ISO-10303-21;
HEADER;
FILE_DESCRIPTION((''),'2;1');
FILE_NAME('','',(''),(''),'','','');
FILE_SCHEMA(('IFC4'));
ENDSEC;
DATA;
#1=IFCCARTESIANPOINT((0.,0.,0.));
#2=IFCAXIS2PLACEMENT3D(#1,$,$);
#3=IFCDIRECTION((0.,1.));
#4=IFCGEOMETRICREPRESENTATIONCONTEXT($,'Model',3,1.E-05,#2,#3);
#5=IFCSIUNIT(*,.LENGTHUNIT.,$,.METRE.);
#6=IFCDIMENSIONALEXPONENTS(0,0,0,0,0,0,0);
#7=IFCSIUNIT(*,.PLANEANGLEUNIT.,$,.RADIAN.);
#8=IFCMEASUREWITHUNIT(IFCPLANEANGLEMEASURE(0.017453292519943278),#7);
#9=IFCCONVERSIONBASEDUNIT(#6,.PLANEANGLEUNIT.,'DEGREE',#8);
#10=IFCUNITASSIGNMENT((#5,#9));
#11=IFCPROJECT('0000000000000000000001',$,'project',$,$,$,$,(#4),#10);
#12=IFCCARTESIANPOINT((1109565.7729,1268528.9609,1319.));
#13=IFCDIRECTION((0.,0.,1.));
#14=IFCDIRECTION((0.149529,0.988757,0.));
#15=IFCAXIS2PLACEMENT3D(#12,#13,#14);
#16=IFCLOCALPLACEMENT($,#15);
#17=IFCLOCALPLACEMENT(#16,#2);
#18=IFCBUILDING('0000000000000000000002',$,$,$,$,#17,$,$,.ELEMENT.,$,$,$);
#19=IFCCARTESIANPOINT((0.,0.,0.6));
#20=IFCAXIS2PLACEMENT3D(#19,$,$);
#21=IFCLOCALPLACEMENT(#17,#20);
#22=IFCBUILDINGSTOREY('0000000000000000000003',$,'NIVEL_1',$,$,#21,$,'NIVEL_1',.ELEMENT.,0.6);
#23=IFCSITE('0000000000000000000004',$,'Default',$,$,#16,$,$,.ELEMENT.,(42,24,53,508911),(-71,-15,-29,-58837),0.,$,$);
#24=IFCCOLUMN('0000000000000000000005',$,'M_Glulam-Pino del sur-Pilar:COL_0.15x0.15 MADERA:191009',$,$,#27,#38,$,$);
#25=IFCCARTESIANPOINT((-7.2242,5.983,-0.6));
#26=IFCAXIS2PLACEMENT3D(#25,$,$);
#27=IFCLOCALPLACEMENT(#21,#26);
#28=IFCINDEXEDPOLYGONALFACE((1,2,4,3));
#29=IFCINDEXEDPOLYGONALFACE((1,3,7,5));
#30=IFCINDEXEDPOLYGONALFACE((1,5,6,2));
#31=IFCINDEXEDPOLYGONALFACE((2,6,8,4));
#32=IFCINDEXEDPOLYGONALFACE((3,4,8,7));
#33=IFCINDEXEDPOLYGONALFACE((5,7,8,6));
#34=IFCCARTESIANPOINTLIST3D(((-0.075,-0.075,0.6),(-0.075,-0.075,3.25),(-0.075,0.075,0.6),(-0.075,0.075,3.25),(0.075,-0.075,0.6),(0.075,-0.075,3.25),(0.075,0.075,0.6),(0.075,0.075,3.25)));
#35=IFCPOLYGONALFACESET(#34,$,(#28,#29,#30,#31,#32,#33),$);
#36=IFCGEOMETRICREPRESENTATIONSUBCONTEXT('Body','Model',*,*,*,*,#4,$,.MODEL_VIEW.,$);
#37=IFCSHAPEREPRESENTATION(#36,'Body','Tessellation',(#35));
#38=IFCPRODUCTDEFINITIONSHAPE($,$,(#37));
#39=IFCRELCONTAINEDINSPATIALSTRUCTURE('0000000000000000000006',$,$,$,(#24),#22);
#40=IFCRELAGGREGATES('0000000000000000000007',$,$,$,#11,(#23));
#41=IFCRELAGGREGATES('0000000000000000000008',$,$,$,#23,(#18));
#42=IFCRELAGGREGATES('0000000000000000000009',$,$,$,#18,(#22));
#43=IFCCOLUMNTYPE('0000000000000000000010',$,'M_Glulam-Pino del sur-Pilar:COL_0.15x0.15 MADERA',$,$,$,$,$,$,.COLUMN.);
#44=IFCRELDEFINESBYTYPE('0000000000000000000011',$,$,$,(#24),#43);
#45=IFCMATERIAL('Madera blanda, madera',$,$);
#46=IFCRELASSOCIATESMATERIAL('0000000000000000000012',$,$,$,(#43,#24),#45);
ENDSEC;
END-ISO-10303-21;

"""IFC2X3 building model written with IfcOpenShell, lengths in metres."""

from ifc_helpers import new_model, entity, si_unit, converted_unit, direction, frame, origin, origin_2d_with_axis, place, context, subcontext, project, spatial, rectangle, extrude, source, transform, mapped, material, type_object, type_shapes, element, save


model = new_model("IFC2X3")

# Units and contexts
model_context = context("Model", 3, precision=1e-05, world=origin(), true_north=direction((0.0, 1.0)))
body_context = subcontext(model_context, "Body", "Model", "MODEL_VIEW")
ifc_project = project(units=[si_unit("LENGTHUNIT", "METRE"), converted_unit("PLANEANGLEUNIT", "DEGREE", entity("IfcPlaneAngleMeasure", 0.017453292519943278), si_unit("PLANEANGLEUNIT", "RADIAN"), dimensions=[0, 0, 0, 0, 0, 0, 0])], contexts=[model_context])

# Site, building, storey
site_placement = place(None, frame((1109565.7729, 1268528.9609, 1319.0), z_axis=(0.0, 0.0, 1.0), x_axis=(0.149529, 0.988757, 0.0)))
site = spatial("IfcSite", under=ifc_project, at=site_placement, Name="Default", CompositionType="ELEMENT", RefLatitude=(42, 24, 53, 508911), RefLongitude=(-71, -15, -29, -58837), RefElevation=0.0)
building_placement = place(site_placement, origin())
building = spatial("IfcBuilding", under=site, at=building_placement, CompositionType="ELEMENT")
storey_placement = place(building_placement, frame((0.0, 0.0, 0.6)))
storey = spatial("IfcBuildingStorey", under=building, at=storey_placement, Name="NIVEL_1", LongName="NIVEL_1", CompositionType="ELEMENT", Elevation=0.6)

# Column
ifc_material_1 = material(Name="Madera blanda, madera")
column_type = type_object("IfcColumnType", Name="M_Glulam-Pino del sur-Pilar:COL_0.15x0.15 MADERA", PredefinedType="COLUMN", material=ifc_material_1)
shared_shape_1 = source(origin(), body_context, "Body", "SweptSolid", [
    extrude(rectangle(XDim=0.15, YDim=0.15, at=origin_2d_with_axis()), frame((0.0, 0.0, 0.6), z_axis=(0.0, 0.0, 1.0), x_axis=(-1.0, 0.0, 0.0)), (0.0, 0.0, 1.0), 2.65),
])
type_shapes(column_type, [shared_shape_1])
column_placement = place(storey_placement, frame((-7.2242, 5.983, -0.6)))
element("IfcColumn", 1, at=column_placement, inside=storey, type_object=column_type, material=ifc_material_1, Name="M_Glulam-Pino del sur-Pilar:COL_0.15x0.15 MADERA:191009", context=body_context, shape_type="MappedRepresentation", body=[
    mapped(shared_shape_1, transform((0.0, 0.0, 0.0), scale=1.0)),
])

save(model, "model.ifc")
